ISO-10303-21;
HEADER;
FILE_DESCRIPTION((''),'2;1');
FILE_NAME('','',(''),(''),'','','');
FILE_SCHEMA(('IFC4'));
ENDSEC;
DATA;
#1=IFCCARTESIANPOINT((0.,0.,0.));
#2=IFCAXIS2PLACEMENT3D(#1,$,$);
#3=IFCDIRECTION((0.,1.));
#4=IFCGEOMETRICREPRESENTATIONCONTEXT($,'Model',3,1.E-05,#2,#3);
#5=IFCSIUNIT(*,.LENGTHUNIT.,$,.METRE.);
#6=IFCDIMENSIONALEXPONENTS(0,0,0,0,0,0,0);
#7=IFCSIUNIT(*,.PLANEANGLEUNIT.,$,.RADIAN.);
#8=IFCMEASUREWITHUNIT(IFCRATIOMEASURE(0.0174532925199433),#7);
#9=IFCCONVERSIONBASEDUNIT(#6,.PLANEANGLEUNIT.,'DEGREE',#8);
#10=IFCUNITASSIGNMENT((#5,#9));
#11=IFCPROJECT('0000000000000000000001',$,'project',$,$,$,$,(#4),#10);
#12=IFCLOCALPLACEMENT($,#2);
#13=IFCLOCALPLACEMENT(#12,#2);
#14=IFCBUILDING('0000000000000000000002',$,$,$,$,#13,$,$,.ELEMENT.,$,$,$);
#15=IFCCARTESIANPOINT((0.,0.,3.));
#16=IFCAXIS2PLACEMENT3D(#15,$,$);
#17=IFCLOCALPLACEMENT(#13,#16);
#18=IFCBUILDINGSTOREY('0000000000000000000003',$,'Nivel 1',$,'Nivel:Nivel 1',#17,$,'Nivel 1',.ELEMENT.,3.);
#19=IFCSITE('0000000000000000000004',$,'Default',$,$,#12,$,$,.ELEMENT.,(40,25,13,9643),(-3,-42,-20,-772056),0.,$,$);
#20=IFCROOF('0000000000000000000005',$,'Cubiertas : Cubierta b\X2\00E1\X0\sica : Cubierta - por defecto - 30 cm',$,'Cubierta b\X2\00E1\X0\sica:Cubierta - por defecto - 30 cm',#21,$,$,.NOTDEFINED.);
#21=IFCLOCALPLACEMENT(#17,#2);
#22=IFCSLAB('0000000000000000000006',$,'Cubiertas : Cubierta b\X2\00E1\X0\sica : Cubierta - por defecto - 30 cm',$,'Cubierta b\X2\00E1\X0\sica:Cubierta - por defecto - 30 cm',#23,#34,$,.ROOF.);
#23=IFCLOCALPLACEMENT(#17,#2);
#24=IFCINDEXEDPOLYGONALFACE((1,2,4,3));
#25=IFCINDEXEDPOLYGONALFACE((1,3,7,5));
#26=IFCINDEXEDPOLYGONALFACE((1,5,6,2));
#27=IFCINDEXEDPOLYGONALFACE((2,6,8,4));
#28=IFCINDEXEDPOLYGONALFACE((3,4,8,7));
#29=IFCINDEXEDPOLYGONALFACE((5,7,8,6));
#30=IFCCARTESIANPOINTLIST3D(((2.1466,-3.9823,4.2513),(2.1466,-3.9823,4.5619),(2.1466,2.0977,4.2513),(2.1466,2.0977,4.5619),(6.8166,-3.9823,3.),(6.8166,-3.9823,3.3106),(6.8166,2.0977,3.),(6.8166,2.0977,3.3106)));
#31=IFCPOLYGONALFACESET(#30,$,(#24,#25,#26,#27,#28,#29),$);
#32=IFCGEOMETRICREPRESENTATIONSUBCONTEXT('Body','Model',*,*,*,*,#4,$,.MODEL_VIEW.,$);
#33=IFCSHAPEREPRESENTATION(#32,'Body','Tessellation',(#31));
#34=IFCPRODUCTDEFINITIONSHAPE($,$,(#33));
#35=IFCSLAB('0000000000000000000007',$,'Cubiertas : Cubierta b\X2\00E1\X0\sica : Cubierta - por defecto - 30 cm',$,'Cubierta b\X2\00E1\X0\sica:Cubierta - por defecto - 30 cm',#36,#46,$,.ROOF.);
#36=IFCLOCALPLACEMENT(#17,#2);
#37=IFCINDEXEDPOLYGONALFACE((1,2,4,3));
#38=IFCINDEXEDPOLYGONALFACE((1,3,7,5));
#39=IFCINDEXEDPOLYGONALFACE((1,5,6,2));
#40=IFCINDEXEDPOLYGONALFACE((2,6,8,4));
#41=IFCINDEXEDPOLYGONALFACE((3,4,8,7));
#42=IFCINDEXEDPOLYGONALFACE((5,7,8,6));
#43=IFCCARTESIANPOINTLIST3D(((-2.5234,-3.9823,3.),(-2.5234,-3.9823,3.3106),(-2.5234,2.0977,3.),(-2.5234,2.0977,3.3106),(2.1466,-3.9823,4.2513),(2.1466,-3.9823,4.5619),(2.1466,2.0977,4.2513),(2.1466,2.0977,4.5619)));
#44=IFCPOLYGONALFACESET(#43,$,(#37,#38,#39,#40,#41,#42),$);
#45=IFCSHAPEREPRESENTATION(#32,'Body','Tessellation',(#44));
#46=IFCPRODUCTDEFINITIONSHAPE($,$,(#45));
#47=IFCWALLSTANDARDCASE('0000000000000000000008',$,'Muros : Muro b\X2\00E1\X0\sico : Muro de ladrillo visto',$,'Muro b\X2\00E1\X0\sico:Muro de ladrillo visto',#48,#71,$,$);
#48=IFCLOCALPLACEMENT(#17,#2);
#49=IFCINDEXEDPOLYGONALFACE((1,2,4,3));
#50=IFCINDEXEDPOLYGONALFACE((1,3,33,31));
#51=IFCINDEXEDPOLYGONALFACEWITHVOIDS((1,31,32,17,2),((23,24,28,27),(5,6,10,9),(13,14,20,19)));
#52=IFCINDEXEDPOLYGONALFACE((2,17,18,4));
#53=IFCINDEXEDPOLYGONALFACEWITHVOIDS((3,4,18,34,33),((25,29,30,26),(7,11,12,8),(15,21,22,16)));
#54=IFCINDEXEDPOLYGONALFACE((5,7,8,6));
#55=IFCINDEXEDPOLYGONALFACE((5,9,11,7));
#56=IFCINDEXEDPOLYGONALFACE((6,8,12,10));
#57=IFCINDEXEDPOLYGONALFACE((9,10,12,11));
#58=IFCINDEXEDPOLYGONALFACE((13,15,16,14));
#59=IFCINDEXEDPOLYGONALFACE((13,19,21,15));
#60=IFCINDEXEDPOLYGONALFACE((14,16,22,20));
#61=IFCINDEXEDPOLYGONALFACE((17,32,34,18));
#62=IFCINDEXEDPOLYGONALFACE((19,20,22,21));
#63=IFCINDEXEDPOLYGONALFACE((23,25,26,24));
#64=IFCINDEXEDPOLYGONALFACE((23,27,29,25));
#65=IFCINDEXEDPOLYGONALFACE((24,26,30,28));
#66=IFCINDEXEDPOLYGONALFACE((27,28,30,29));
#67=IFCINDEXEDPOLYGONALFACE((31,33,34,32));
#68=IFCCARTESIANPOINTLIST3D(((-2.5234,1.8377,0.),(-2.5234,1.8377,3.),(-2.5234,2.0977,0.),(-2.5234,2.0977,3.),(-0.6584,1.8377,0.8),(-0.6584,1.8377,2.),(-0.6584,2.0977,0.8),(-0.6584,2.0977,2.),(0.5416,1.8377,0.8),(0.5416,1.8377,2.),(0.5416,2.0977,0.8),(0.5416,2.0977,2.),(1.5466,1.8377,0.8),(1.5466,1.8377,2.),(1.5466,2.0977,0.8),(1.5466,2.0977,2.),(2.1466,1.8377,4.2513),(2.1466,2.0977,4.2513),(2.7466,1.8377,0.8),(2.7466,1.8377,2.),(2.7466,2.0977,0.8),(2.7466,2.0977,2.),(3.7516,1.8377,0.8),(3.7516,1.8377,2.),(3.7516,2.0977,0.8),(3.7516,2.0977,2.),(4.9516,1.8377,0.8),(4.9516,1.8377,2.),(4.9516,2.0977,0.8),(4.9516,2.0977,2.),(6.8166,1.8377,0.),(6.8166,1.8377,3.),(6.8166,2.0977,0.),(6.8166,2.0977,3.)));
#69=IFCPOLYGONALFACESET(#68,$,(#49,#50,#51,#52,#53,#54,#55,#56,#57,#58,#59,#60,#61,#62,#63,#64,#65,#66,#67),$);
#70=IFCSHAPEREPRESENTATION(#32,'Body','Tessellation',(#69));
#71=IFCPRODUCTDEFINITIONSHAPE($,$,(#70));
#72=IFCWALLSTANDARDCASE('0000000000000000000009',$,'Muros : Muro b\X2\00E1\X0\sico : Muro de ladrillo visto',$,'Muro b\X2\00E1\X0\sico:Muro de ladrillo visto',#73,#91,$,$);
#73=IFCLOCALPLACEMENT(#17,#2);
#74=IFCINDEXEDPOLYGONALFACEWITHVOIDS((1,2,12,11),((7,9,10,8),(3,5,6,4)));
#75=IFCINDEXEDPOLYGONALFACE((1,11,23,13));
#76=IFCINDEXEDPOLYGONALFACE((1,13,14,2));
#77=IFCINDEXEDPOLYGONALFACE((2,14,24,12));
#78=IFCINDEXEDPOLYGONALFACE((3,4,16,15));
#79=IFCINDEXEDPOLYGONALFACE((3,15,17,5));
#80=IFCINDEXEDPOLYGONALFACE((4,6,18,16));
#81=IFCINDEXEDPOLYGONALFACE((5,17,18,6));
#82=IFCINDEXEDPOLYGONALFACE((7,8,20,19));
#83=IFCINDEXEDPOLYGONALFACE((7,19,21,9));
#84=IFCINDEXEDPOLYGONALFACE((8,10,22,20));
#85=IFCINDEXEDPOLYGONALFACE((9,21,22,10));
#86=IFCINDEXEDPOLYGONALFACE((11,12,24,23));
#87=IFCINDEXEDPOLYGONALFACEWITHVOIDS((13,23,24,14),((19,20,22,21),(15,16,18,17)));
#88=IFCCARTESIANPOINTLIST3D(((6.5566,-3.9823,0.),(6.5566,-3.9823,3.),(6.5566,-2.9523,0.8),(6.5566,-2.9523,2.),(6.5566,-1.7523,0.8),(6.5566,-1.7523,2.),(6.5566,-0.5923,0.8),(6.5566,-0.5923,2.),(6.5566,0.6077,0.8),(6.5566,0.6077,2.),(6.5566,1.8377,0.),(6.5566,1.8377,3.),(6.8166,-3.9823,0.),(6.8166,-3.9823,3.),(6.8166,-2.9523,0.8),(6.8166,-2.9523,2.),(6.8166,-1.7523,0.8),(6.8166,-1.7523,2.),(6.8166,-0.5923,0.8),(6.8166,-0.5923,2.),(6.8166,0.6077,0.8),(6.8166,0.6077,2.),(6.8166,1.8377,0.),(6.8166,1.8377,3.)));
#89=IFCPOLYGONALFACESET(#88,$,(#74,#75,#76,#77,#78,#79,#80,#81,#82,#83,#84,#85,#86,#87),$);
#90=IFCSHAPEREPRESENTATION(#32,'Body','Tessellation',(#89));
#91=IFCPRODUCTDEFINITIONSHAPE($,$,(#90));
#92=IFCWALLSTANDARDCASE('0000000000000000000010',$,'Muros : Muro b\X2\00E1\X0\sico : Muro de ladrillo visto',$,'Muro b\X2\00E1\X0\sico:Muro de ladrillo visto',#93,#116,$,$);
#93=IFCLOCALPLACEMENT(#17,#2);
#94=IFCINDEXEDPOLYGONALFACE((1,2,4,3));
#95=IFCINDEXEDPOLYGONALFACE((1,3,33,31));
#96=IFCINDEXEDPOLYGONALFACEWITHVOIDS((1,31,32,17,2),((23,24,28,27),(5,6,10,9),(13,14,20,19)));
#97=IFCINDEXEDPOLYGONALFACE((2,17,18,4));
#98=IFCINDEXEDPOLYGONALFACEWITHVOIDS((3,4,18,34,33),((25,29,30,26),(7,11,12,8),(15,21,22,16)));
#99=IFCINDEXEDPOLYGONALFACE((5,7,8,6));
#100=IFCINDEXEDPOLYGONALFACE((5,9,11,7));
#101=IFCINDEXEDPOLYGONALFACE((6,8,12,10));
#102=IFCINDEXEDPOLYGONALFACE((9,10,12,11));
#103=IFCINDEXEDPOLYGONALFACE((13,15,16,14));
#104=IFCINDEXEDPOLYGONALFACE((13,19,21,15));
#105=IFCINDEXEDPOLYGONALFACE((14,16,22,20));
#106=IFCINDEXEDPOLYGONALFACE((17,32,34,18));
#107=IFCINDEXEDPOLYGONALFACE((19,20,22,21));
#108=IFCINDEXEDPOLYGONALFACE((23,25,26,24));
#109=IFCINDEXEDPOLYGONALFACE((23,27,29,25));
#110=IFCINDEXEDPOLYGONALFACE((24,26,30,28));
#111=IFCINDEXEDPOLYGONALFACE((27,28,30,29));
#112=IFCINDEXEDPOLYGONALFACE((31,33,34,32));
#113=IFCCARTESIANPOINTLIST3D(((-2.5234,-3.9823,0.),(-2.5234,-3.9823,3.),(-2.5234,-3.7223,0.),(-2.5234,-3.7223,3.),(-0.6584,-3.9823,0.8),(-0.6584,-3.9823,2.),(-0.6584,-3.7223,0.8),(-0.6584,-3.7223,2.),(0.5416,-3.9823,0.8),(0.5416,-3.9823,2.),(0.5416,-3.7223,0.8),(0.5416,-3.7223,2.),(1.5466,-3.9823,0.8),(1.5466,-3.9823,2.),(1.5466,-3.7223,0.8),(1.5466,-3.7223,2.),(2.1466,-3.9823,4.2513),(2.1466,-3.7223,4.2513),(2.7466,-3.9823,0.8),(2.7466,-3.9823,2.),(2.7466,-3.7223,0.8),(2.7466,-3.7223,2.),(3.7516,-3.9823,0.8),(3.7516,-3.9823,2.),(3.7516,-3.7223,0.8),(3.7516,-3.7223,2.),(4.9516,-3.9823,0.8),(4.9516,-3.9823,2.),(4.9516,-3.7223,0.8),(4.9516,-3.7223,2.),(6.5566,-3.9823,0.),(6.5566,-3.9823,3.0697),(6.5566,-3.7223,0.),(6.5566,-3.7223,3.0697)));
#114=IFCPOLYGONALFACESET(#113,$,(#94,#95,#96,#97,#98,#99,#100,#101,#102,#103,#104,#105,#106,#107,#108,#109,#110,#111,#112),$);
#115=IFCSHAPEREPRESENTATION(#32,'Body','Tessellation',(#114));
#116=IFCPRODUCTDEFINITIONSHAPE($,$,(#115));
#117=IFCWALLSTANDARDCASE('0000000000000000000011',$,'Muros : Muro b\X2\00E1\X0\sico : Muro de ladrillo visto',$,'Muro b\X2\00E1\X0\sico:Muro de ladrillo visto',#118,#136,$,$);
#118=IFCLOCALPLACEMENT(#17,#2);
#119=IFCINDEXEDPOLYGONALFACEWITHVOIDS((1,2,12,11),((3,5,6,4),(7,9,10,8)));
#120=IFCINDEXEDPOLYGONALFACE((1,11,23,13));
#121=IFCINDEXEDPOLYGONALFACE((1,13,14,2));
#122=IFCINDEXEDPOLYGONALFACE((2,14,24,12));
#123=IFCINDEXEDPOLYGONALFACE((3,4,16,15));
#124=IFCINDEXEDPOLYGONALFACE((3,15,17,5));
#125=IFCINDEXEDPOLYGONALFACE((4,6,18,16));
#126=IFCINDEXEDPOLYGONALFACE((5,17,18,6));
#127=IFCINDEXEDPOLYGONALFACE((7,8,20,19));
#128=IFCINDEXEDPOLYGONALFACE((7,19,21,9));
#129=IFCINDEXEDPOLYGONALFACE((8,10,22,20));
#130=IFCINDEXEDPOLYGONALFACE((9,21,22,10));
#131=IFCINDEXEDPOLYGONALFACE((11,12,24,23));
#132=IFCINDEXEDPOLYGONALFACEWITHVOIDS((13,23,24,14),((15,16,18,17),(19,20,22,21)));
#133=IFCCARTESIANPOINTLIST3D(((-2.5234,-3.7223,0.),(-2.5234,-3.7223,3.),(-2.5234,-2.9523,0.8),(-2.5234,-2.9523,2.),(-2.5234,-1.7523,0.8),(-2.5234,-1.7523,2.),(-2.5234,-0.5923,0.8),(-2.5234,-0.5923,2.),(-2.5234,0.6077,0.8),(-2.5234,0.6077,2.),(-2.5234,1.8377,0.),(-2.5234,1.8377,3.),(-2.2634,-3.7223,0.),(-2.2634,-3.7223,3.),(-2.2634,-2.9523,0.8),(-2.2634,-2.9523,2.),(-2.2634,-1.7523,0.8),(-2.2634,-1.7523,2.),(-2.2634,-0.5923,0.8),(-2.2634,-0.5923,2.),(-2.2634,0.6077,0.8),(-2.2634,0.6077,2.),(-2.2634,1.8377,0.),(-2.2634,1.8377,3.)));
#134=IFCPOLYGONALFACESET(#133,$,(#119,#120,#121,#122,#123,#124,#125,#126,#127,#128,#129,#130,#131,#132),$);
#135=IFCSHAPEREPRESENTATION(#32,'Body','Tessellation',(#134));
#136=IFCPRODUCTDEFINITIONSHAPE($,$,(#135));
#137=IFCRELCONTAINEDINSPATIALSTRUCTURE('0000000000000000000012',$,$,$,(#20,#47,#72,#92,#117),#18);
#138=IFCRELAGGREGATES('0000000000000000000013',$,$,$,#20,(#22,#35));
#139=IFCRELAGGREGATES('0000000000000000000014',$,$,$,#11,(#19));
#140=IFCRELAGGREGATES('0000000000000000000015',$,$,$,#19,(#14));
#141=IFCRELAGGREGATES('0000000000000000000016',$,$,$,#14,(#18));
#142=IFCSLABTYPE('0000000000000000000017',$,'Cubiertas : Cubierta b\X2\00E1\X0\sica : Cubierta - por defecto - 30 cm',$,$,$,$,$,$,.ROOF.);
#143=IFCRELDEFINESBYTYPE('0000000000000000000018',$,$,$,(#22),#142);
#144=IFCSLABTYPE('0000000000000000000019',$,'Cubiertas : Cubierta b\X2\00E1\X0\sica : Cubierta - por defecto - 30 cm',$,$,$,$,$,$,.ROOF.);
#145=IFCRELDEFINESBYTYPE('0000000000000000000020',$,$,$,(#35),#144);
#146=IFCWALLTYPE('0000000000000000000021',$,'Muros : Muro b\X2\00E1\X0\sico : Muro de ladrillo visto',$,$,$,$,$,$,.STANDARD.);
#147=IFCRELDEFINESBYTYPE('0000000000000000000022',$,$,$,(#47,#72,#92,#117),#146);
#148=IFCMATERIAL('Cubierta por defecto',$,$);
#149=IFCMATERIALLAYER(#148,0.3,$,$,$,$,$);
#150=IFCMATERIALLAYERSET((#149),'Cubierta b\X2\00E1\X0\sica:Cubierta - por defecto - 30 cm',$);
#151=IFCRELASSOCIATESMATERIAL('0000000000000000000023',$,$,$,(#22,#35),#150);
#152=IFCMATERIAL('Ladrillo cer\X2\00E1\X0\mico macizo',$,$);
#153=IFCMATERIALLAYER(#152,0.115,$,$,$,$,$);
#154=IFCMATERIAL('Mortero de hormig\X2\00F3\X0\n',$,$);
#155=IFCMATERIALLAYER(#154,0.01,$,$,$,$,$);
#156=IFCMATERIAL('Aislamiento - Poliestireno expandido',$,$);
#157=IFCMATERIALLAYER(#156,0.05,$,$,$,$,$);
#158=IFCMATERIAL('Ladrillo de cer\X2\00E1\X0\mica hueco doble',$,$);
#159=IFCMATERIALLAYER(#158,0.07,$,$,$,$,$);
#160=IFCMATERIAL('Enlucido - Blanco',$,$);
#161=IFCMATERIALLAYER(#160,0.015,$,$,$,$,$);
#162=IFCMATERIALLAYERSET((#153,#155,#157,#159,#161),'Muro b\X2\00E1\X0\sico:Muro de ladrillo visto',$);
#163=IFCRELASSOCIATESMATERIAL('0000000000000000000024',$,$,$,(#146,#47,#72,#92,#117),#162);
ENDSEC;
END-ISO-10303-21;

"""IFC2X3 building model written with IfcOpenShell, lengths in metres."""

from ifc_helpers import new_model, entity, si_unit, converted_unit, direction, frame, frame_2d, origin, place, context, subcontext, project, spatial, polyline, rectangle, extrude, clip, bounded_halfspace, material, layer, layer_set, layer_usage, type_object, element, aggregate, save


model = new_model("IFC2X3")

# Units and contexts
model_context = context("Model", 3, precision=1e-05, world=origin(), true_north=direction((0.0, 1.0)))
body_context = subcontext(model_context, "Body", "Model", "MODEL_VIEW")
ifc_project = project(units=[si_unit("LENGTHUNIT", "METRE"), converted_unit("PLANEANGLEUNIT", "DEGREE", entity("IfcRatioMeasure", 0.0174532925199433), si_unit("PLANEANGLEUNIT", "RADIAN"), dimensions=[0, 0, 0, 0, 0, 0, 0])], contexts=[model_context])

# Site, building, storey
site_placement = place(None, origin())
site = spatial("IfcSite", under=ifc_project, at=site_placement, Name="Default", CompositionType="ELEMENT", RefLatitude=(40, 25, 13, 9643), RefLongitude=(-3, -42, -20, -772056), RefElevation=0.0)
building_placement = place(site_placement, origin())
building = spatial("IfcBuilding", under=site, at=building_placement, CompositionType="ELEMENT")
storey_placement = place(building_placement, frame((0.0, 0.0, 3.0)))
storey = spatial("IfcBuildingStorey", under=building, at=storey_placement, Name="Nivel 1", ObjectType="Nivel:Nivel 1", LongName="Nivel 1", CompositionType="ELEMENT", Elevation=3.0)

# Roof, slabs
roof_placement = place(storey_placement, frame((-2.5234, -3.9823, 3.0)))
roof = element("IfcRoof", 1, at=roof_placement, inside=storey, Name="Cubiertas : Cubierta básica : Cubierta - por defecto - 30 cm", ObjectType="Cubierta básica:Cubierta - por defecto - 30 cm", ShapeType="NOTDEFINED")
ifc_material_1 = material(Name="Cubierta por defecto")
ifc_layer_1 = layer(ifc_material_1, 0.3)
ifc_layer_set_1 = layer_set([ifc_layer_1], Name="Cubierta básica:Cubierta - por defecto - 30 cm")
slab_type_1 = type_object("IfcSlabType", Name="Cubiertas : Cubierta básica : Cubierta - por defecto - 30 cm", PredefinedType="ROOF")
slab_1_placement = place(roof_placement, origin())
slab_1 = element("IfcSlab", 2, at=slab_1_placement, type_object=slab_type_1, material=ifc_layer_set_1, Name="Cubiertas : Cubierta básica : Cubierta - por defecto - 30 cm", ObjectType="Cubierta básica:Cubierta - por defecto - 30 cm", PredefinedType="ROOF", context=body_context, shape_type="SweptSolid", body=[
    extrude(rectangle(XDim=4.8347, YDim=6.08, at=frame_2d((0.0, 0.0), x_axis=(1.0, 0.0))), frame((7.005, 3.04, 0.6257), z_axis=(0.258819, 0.0, 0.965926), x_axis=(0.965926, 0.0, -0.258819)), (-0.258819, 0.0, 0.965926), 0.3106),
])
slab_type_2 = type_object("IfcSlabType", Name="Cubiertas : Cubierta básica : Cubierta - por defecto - 30 cm", PredefinedType="ROOF")
slab_2_placement = place(roof_placement, origin())
slab_2 = element("IfcSlab", 3, at=slab_2_placement, type_object=slab_type_2, material=ifc_layer_set_1, Name="Cubiertas : Cubierta básica : Cubierta - por defecto - 30 cm", ObjectType="Cubierta básica:Cubierta - por defecto - 30 cm", PredefinedType="ROOF", context=body_context, shape_type="SweptSolid", body=[
    extrude(rectangle(XDim=6.08, YDim=4.8347, at=frame_2d((0.0, 0.0), x_axis=(0.0, 1.0))), frame((2.335, 3.04, 0.6257), z_axis=(-0.258819, 0.0, 0.965926), x_axis=(0.965926, 0.0, 0.258819)), (0.258819, 0.0, 0.965926), 0.3106),
])
aggregate(roof, [slab_1, slab_2])

# Walls, openings
ifc_material_2 = material(Name="Ladrillo cerámico macizo")
ifc_layer_2 = layer(ifc_material_2, 0.115)
ifc_material_3 = material(Name="Mortero de hormigón")
ifc_layer_3 = layer(ifc_material_3, 0.01)
ifc_material_4 = material(Name="Aislamiento - Poliestireno expandido")
ifc_layer_4 = layer(ifc_material_4, 0.05)
ifc_material_5 = material(Name="Ladrillo de cerámica hueco doble")
ifc_layer_5 = layer(ifc_material_5, 0.07)
ifc_material_6 = material(Name="Enlucido - Blanco")
ifc_layer_6 = layer(ifc_material_6, 0.015)
ifc_layer_set_2 = layer_set([ifc_layer_2, ifc_layer_3, ifc_layer_4, ifc_layer_5, ifc_layer_6], Name="Muro básico:Muro de ladrillo visto")
ifc_layer_usage_1 = layer_usage(ifc_layer_set_2, "AXIS2", "NEGATIVE", 0.13)
wall_type_1 = type_object("IfcWallType", Name="Muros : Muro básico : Muro de ladrillo visto", PredefinedType="STANDARD", material=ifc_layer_set_2)
wall_1_placement = place(storey_placement, frame((-2.5234, 1.9677, 0.0)))
wall_1 = element("IfcWallStandardCase", 4, at=wall_1_placement, inside=storey, type_object=wall_type_1, material=ifc_layer_usage_1, Name="Muros : Muro básico : Muro de ladrillo visto", ObjectType="Muro básico:Muro de ladrillo visto", context=body_context, shape_type="Clipping", body=[
    clip(clip(extrude(rectangle(XDim=9.34, YDim=0.26, at=frame_2d((4.67, 0.0), x_axis=(-1.0, 0.0))), origin(), (0.0, 0.0, 1.0), 4.2513), bounded_halfspace(frame((4.67, -0.13, 4.2513), z_axis=(0.258819, 0.0, 0.965926), x_axis=(0.0, 1.0, 0.0)), False, frame((4.67, -0.13, 4.2513)), polyline([(0.0, 0.0), (4.67, 0.0), (4.67, 0.26), (0.0, 0.26), (0.0, 0.0)]))), bounded_halfspace(frame((0.0, -0.13, 3.0), z_axis=(-0.258819, 0.0, 0.965926), x_axis=(0.0, -1.0, 0.0)), False, frame((0.0, -0.13, 3.0)), polyline([(0.0, 0.0), (4.67, 0.0), (4.67, 0.26), (0.0, 0.26), (0.0, 0.0)]))),
])
opening_1_placement = place(wall_1_placement, frame((3.065, 0.13, 0.8)))
element("IfcOpeningElement", 5, at=opening_1_placement, cuts=wall_1, ObjectType="Opening", context=body_context, shape_type="SweptSolid", body=[
    extrude(rectangle(XDim=1.2, YDim=1.2, at=frame_2d((0.6, 0.6), x_axis=(1.0, 0.0))), frame((0.0, 0.0, 0.0), z_axis=(0.0, -1.0, 0.0), x_axis=(0.0, 0.0, 1.0)), (0.0, 0.0, 1.0), 0.26),
])
opening_2_placement = place(wall_1_placement, frame((5.27, 0.13, 0.8)))
element("IfcOpeningElement", 6, at=opening_2_placement, cuts=wall_1, ObjectType="Opening", context=body_context, shape_type="SweptSolid", body=[
    extrude(rectangle(XDim=1.2, YDim=1.2, at=frame_2d((0.6, 0.6), x_axis=(1.0, 0.0))), frame((0.0, 0.0, 0.0), z_axis=(0.0, -1.0, 0.0), x_axis=(0.0, 0.0, 1.0)), (0.0, 0.0, 1.0), 0.26),
])
opening_3_placement = place(wall_1_placement, frame((7.475, 0.13, 0.8)))
element("IfcOpeningElement", 7, at=opening_3_placement, cuts=wall_1, ObjectType="Opening", context=body_context, shape_type="SweptSolid", body=[
    extrude(rectangle(XDim=1.2, YDim=1.2, at=frame_2d((0.6, 0.6), x_axis=(1.0, 0.0))), frame((0.0, 0.0, 0.0), z_axis=(0.0, -1.0, 0.0), x_axis=(0.0, 0.0, 1.0)), (0.0, 0.0, 1.0), 0.26),
])
ifc_layer_usage_2 = layer_usage(ifc_layer_set_2, "AXIS2", "NEGATIVE", 0.13)
wall_2_placement = place(storey_placement, frame((6.6866, 1.8377, 0.0), z_axis=(0.0, 0.0, 1.0), x_axis=(0.0, -1.0, 0.0)))
wall_2 = element("IfcWallStandardCase", 8, at=wall_2_placement, inside=storey, type_object=wall_type_1, material=ifc_layer_usage_2, Name="Muros : Muro básico : Muro de ladrillo visto", ObjectType="Muro básico:Muro de ladrillo visto", context=body_context, shape_type="SweptSolid", body=[
    extrude(rectangle(XDim=5.82, YDim=0.26, at=frame_2d((2.91, 0.0), x_axis=(-1.0, 0.0))), origin(), (0.0, 0.0, 1.0), 3.0),
])
opening_4_placement = place(wall_2_placement, frame((3.59, -0.13, 0.8)))
element("IfcOpeningElement", 9, at=opening_4_placement, cuts=wall_2, ObjectType="Opening", context=body_context, shape_type="SweptSolid", body=[
    extrude(rectangle(XDim=1.2, YDim=1.2, at=frame_2d((0.6, 0.6), x_axis=(1.0, 0.0))), frame((0.0, 0.0, 0.0), z_axis=(0.0, 1.0, 0.0), x_axis=(0.0, 0.0, 1.0)), (0.0, 0.0, 1.0), 0.26),
])
opening_5_placement = place(wall_2_placement, frame((2.43, 0.13, 0.8)))
element("IfcOpeningElement", 10, at=opening_5_placement, cuts=wall_2, ObjectType="Opening", context=body_context, shape_type="SweptSolid", body=[
    extrude(rectangle(XDim=1.2, YDim=1.2, at=frame_2d((0.6, 0.6), x_axis=(1.0, 0.0))), frame((0.0, 0.0, 0.0), z_axis=(0.0, -1.0, 0.0), x_axis=(0.0, 0.0, 1.0)), (0.0, 0.0, 1.0), 0.26),
])
ifc_layer_usage_3 = layer_usage(ifc_layer_set_2, "AXIS2", "NEGATIVE", 0.13)
wall_3_placement = place(storey_placement, frame((6.5566, -3.8523, 0.0), z_axis=(0.0, 0.0, 1.0), x_axis=(-1.0, 0.0, 0.0)))
wall_3 = element("IfcWallStandardCase", 11, at=wall_3_placement, inside=storey, type_object=wall_type_1, material=ifc_layer_usage_3, Name="Muros : Muro básico : Muro de ladrillo visto", ObjectType="Muro básico:Muro de ladrillo visto", context=body_context, shape_type="Clipping", body=[
    clip(clip(extrude(rectangle(XDim=9.08, YDim=0.26, at=frame_2d((4.54, 0.0), x_axis=(-1.0, 0.0))), origin(), (0.0, 0.0, 1.0), 4.2513), bounded_halfspace(frame((0.0, -0.13, 3.0697), z_axis=(-0.258819, 0.0, 0.965926), x_axis=(0.0, -1.0, 0.0)), False, frame((0.0, -0.13, 3.0697)), polyline([(0.0, 0.0), (4.41, 0.0), (4.41, 0.26), (0.0, 0.26), (0.0, 0.0)]))), bounded_halfspace(frame((4.41, -0.13, 4.2513), z_axis=(0.258819, 0.0, 0.965926), x_axis=(0.0, 1.0, 0.0)), False, frame((4.41, -0.13, 4.2513)), polyline([(0.0, 0.0), (4.67, 0.0), (4.67, 0.26), (0.0, 0.26), (0.0, 0.0)]))),
])
opening_6_placement = place(wall_3_placement, frame((7.215, 0.13, 0.8)))
element("IfcOpeningElement", 12, at=opening_6_placement, cuts=wall_3, ObjectType="Opening", context=body_context, shape_type="SweptSolid", body=[
    extrude(rectangle(XDim=1.2, YDim=1.2, at=frame_2d((0.6, 0.6), x_axis=(1.0, 0.0))), frame((0.0, 0.0, 0.0), z_axis=(0.0, -1.0, 0.0), x_axis=(0.0, 0.0, 1.0)), (0.0, 0.0, 1.0), 0.26),
])
opening_7_placement = place(wall_3_placement, frame((5.01, 0.13, 0.8)))
element("IfcOpeningElement", 13, at=opening_7_placement, cuts=wall_3, ObjectType="Opening", context=body_context, shape_type="SweptSolid", body=[
    extrude(rectangle(XDim=1.2, YDim=1.2, at=frame_2d((0.6, 0.6), x_axis=(1.0, 0.0))), frame((0.0, 0.0, 0.0), z_axis=(0.0, -1.0, 0.0), x_axis=(0.0, 0.0, 1.0)), (0.0, 0.0, 1.0), 0.26),
])
opening_8_placement = place(wall_3_placement, frame((2.805, 0.13, 0.8)))
element("IfcOpeningElement", 14, at=opening_8_placement, cuts=wall_3, ObjectType="Opening", context=body_context, shape_type="SweptSolid", body=[
    extrude(rectangle(XDim=1.2, YDim=1.2, at=frame_2d((0.6, 0.6), x_axis=(1.0, 0.0))), frame((0.0, 0.0, 0.0), z_axis=(0.0, -1.0, 0.0), x_axis=(0.0, 0.0, 1.0)), (0.0, 0.0, 1.0), 0.26),
])
ifc_layer_usage_4 = layer_usage(ifc_layer_set_2, "AXIS2", "NEGATIVE", 0.13)
wall_4_placement = place(storey_placement, frame((-2.3934, -3.7223, 0.0), z_axis=(0.0, 0.0, 1.0), x_axis=(0.0, 1.0, 0.0)))
wall_4 = element("IfcWallStandardCase", 15, at=wall_4_placement, inside=storey, type_object=wall_type_1, material=ifc_layer_usage_4, Name="Muros : Muro básico : Muro de ladrillo visto", ObjectType="Muro básico:Muro de ladrillo visto", context=body_context, shape_type="SweptSolid", body=[
    extrude(rectangle(XDim=5.56, YDim=0.26, at=frame_2d((2.78, 0.0), x_axis=(-1.0, 0.0))), origin(), (0.0, 0.0, 1.0), 3.0),
])
opening_9_placement = place(wall_4_placement, frame((4.33, 0.13, 0.8)))
element("IfcOpeningElement", 16, at=opening_9_placement, cuts=wall_4, ObjectType="Opening", context=body_context, shape_type="SweptSolid", body=[
    extrude(rectangle(XDim=1.2, YDim=1.2, at=frame_2d((0.6, 0.6), x_axis=(1.0, 0.0))), frame((0.0, 0.0, 0.0), z_axis=(0.0, -1.0, 0.0), x_axis=(0.0, 0.0, 1.0)), (0.0, 0.0, 1.0), 0.26),
])
opening_10_placement = place(wall_4_placement, frame((1.97, 0.13, 0.8)))
element("IfcOpeningElement", 17, at=opening_10_placement, cuts=wall_4, ObjectType="Opening", context=body_context, shape_type="SweptSolid", body=[
    extrude(rectangle(XDim=1.2, YDim=1.2, at=frame_2d((0.6, 0.6), x_axis=(1.0, 0.0))), frame((0.0, 0.0, 0.0), z_axis=(0.0, -1.0, 0.0), x_axis=(0.0, 0.0, 1.0)), (0.0, 0.0, 1.0), 0.26),
])

save(model, "model.ifc")
